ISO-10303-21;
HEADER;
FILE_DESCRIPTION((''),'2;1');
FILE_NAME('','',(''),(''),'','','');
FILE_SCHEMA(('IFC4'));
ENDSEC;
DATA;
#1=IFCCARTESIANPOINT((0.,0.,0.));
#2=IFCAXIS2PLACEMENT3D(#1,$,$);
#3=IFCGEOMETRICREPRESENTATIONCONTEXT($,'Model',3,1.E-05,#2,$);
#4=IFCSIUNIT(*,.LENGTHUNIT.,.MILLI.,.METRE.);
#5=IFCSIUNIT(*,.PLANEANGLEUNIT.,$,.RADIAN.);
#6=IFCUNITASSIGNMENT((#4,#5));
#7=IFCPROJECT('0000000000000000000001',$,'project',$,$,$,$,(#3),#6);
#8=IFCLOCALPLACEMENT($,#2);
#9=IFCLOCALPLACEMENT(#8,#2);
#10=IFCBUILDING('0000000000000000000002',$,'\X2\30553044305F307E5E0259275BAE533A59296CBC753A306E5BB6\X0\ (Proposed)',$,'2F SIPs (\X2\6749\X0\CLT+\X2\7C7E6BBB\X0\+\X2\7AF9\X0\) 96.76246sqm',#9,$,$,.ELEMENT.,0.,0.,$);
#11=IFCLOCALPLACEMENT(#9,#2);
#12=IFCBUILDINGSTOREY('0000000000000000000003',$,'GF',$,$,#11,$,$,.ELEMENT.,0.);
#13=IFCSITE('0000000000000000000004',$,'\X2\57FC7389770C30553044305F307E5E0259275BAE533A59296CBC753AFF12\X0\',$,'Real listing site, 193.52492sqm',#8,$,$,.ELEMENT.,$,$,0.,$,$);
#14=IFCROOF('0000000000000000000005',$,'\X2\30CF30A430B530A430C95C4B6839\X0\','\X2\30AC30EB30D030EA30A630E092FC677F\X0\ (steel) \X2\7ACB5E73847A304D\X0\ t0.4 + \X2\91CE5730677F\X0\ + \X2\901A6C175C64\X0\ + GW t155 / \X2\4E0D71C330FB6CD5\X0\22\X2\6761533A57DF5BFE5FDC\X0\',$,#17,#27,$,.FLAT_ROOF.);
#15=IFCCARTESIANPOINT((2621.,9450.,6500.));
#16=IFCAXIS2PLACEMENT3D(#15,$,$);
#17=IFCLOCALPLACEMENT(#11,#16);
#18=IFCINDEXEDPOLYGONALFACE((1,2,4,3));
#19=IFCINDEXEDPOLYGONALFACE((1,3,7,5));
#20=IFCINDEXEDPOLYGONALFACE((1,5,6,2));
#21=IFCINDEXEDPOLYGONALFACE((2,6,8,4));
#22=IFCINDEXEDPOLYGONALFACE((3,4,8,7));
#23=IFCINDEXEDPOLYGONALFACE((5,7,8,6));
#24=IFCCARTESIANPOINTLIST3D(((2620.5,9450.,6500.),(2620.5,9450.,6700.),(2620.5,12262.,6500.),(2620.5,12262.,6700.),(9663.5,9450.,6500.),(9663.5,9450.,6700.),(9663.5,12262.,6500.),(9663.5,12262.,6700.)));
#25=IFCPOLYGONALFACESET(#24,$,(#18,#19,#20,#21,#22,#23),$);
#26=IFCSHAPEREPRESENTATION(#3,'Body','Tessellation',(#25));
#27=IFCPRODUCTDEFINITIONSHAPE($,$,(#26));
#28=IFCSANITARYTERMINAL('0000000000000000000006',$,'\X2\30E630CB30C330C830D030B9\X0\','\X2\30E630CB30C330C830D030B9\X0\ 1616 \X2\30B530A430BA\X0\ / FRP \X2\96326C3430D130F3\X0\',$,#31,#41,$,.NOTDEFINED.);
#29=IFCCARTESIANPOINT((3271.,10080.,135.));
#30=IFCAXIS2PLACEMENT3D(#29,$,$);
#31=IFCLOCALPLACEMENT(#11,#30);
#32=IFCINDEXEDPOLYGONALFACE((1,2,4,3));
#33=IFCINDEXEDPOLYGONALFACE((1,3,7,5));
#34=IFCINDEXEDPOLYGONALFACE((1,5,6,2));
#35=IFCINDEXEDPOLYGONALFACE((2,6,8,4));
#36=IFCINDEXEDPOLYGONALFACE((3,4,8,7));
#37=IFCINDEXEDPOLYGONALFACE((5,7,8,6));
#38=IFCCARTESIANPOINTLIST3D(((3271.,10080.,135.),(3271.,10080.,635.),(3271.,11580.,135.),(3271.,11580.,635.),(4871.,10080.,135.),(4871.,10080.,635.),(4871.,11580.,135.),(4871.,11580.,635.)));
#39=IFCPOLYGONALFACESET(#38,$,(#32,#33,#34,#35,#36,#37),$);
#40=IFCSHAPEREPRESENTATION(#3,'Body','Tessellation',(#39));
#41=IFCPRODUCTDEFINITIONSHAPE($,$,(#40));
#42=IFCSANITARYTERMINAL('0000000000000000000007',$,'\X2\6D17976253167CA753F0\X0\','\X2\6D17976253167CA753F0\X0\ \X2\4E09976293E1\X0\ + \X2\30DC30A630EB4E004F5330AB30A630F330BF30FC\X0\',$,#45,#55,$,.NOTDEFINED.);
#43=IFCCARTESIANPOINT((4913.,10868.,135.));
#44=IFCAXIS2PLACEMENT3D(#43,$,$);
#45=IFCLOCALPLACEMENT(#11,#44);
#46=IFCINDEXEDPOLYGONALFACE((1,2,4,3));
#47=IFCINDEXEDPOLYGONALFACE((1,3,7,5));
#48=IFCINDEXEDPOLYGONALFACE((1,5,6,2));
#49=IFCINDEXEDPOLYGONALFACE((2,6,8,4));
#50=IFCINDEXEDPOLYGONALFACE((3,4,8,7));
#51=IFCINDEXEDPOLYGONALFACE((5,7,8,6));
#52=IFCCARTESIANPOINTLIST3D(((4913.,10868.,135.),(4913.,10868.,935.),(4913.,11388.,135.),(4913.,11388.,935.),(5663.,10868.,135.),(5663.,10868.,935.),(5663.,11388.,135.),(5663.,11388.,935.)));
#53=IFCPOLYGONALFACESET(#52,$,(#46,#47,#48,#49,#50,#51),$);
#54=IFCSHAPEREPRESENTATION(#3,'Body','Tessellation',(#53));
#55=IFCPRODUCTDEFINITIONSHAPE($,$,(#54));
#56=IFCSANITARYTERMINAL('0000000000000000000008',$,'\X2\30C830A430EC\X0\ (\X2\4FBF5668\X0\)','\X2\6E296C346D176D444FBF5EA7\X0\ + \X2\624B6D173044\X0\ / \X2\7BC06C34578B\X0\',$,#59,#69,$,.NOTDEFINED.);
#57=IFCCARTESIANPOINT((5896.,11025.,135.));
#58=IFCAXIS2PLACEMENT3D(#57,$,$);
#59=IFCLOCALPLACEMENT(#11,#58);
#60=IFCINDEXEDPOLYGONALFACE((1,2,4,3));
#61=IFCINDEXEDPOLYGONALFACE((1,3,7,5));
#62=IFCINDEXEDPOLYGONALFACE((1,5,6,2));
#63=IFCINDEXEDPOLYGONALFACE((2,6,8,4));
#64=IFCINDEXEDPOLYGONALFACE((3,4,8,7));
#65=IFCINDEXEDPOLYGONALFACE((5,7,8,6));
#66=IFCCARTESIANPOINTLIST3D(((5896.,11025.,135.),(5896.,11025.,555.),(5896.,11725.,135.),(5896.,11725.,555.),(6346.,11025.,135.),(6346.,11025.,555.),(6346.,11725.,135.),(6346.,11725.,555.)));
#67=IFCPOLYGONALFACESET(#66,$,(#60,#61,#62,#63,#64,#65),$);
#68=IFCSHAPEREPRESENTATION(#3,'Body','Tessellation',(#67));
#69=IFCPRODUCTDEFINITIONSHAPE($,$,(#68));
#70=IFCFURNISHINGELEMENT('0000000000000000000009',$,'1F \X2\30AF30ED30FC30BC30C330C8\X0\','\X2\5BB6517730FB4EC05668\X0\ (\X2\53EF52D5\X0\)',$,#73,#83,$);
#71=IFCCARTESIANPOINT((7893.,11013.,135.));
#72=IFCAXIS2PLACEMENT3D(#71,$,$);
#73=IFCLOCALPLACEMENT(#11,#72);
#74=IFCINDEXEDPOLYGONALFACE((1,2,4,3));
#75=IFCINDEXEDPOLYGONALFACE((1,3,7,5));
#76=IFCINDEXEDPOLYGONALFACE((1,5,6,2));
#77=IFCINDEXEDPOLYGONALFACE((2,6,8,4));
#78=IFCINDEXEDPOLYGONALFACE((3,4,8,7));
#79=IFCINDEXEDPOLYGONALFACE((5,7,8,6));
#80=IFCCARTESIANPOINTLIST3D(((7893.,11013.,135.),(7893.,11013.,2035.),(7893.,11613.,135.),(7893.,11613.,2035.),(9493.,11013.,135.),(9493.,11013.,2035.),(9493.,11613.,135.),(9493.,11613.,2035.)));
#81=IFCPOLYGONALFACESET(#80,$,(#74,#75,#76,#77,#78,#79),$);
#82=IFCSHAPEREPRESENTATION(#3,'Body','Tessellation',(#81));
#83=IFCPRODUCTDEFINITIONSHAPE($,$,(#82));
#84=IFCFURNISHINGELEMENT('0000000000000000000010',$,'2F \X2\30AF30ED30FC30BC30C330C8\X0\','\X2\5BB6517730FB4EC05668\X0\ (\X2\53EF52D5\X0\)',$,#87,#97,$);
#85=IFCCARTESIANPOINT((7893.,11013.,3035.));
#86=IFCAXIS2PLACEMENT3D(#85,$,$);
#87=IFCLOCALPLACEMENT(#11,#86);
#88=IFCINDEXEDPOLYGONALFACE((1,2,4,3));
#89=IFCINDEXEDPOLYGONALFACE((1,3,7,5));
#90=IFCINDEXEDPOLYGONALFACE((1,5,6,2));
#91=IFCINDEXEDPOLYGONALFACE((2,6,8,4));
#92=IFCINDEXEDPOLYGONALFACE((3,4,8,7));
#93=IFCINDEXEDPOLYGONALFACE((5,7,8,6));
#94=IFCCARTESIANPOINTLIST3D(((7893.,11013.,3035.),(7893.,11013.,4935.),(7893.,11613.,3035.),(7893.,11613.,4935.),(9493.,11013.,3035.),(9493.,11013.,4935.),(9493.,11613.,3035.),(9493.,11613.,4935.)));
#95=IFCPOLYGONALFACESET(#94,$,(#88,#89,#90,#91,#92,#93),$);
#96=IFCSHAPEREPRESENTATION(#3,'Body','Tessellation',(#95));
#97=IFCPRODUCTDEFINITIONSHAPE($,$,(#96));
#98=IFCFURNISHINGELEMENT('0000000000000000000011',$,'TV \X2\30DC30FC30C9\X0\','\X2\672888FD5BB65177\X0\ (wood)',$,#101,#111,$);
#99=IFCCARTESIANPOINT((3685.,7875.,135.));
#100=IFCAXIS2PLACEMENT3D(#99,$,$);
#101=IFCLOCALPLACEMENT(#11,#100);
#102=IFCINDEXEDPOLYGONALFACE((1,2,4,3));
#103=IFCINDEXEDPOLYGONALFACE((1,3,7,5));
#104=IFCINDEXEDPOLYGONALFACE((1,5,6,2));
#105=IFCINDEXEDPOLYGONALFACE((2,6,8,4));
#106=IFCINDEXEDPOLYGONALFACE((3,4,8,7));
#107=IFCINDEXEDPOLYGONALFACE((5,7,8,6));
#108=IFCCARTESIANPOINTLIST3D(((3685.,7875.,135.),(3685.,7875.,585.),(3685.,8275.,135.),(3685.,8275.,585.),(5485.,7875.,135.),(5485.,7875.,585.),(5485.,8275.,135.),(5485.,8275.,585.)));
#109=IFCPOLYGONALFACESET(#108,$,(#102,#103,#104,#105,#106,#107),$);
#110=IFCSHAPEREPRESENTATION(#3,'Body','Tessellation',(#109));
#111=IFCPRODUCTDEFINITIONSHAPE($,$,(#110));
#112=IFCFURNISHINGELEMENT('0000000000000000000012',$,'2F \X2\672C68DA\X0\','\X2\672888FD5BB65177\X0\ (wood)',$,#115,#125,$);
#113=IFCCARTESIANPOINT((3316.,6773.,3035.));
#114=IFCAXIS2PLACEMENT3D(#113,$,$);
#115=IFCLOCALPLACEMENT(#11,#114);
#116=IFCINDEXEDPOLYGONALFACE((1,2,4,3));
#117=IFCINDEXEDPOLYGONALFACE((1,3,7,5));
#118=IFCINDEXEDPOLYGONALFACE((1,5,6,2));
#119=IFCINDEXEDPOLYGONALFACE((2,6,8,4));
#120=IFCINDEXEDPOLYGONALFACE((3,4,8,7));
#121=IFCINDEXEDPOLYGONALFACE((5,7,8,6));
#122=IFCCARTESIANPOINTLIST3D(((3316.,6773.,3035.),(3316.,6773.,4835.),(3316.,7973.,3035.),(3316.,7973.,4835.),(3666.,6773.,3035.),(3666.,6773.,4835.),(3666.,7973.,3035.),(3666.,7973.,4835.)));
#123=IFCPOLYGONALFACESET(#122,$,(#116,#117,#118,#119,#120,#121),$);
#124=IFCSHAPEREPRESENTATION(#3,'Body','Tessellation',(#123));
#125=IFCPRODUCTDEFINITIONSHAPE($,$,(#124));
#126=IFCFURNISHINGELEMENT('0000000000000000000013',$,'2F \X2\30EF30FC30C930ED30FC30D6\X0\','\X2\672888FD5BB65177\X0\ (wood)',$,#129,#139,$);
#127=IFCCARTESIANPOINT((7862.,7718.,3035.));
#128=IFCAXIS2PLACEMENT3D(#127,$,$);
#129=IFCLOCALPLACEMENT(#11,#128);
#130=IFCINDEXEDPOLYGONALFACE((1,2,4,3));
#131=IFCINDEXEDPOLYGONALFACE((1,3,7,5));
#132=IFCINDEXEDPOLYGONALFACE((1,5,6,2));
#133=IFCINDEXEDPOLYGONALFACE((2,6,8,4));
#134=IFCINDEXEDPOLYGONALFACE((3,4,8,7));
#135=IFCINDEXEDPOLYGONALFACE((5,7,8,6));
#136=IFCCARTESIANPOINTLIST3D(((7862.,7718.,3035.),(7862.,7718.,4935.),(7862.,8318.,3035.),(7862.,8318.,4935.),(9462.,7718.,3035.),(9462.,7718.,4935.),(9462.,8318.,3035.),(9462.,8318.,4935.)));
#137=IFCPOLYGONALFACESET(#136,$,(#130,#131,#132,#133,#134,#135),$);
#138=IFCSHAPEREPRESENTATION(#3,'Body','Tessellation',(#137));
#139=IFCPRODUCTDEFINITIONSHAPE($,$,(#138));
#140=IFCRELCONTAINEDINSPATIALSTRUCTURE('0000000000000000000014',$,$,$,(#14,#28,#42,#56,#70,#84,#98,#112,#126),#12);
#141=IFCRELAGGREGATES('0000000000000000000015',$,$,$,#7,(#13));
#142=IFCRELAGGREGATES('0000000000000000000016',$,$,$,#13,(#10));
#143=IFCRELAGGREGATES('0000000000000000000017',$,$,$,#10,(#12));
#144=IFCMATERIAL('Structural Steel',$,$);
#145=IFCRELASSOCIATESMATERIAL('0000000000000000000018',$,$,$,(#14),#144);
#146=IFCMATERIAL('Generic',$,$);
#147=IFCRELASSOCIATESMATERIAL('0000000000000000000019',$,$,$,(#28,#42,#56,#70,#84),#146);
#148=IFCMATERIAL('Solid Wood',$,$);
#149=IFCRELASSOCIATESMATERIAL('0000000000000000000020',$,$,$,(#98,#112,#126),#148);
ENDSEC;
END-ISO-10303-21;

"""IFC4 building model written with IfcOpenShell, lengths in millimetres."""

from ifc_helpers import new_model, si_unit, frame, frame_2d, origin, place, context, project, spatial, rectangle, extrude, material, element, save


model = new_model("IFC4")

# Units and contexts
model_context = context("Model", 3, precision=1e-05, world=origin())
ifc_project = project(units=[si_unit("LENGTHUNIT", "METRE", prefix="MILLI"), si_unit("PLANEANGLEUNIT", "RADIAN")], contexts=[model_context])

# Site, building, storey
site_placement = place(None, origin())
site = spatial("IfcSite", under=ifc_project, at=site_placement, Name="埼玉県さいたま市大宮区天沼町２", ObjectType="Real listing site, 193.52492sqm", CompositionType="ELEMENT", RefElevation=0.0)
building_placement = place(site_placement, origin())
building = spatial("IfcBuilding", under=site, at=building_placement, Name="さいたま市大宮区天沼町の家 (Proposed)", ObjectType="2F SIPs (杉CLT+籾殻+竹) 96.76246sqm", CompositionType="ELEMENT", ElevationOfRefHeight=0.0, ElevationOfTerrain=0.0)
storey_placement = place(building_placement, origin())
storey = spatial("IfcBuildingStorey", under=building, at=storey_placement, Name="GF", CompositionType="ELEMENT", Elevation=0.0)

# Shared definitions
ifc_material_1 = material(Name="Solid Wood")

# Roof
ifc_material_2 = material(Name="Structural Steel")
roof_placement = place(storey_placement, frame((2621.0, 9450.0, 6500.0)))
element("IfcRoof", 1, at=roof_placement, inside=storey, material=ifc_material_2, Name="ハイサイド屋根", Description="ガルバリウム鋼板 (steel) 立平葺き t0.4 + 野地板 + 通気層 + GW t155 / 不燃・法22条区域対応", PredefinedType="FLAT_ROOF", context=model_context, shape_type="SweptSolid", body=[
    extrude(rectangle(XDim=7043.0, YDim=2812.0, at=frame_2d((3521.0, 1406.0))), frame((2621.0, 9450.0, 6500.0)), (0.0, 0.0, 1.0), 200.0),
])

# Sanitary terminals
ifc_material_3 = material(Name="Generic")
sanitary_terminal_1_placement = place(storey_placement, frame((3271.0, 10080.0, 135.0)))
element("IfcSanitaryTerminal", 2, at=sanitary_terminal_1_placement, inside=storey, material=ifc_material_3, Name="ユニットバス", Description="ユニットバス 1616 サイズ / FRP 防水パン", PredefinedType="NOTDEFINED", context=model_context, shape_type="SweptSolid", body=[
    extrude(rectangle(XDim=1600.0, YDim=1500.0, at=frame_2d((800.0, 750.0))), frame((3271.0, 10080.0, 135.0)), (0.0, 0.0, 1.0), 500.0),
])
sanitary_terminal_2_placement = place(storey_placement, frame((4913.0, 10868.0, 135.0)))
element("IfcSanitaryTerminal", 3, at=sanitary_terminal_2_placement, inside=storey, material=ifc_material_3, Name="洗面化粧台", Description="洗面化粧台 三面鏡 + ボウル一体カウンター", PredefinedType="NOTDEFINED", context=model_context, shape_type="SweptSolid", body=[
    extrude(rectangle(XDim=750.0, YDim=520.0, at=frame_2d((375.0, 260.0))), frame((4913.0, 10868.0, 135.0)), (0.0, 0.0, 1.0), 800.0),
])
sanitary_terminal_3_placement = place(storey_placement, frame((5896.0, 11025.0, 135.0)))
element("IfcSanitaryTerminal", 4, at=sanitary_terminal_3_placement, inside=storey, material=ifc_material_3, Name="トイレ (便器)", Description="温水洗浄便座 + 手洗い / 節水型", PredefinedType="NOTDEFINED", context=model_context, shape_type="SweptSolid", body=[
    extrude(rectangle(XDim=450.0, YDim=700.0, at=frame_2d((225.0, 350.0))), frame((5896.0, 11025.0, 135.0)), (0.0, 0.0, 1.0), 420.0),
])

# Furnishing elements
furnishing_1_placement = place(storey_placement, frame((7893.0, 11013.0, 135.0)))
element("IfcFurnishingElement", 5, at=furnishing_1_placement, inside=storey, material=ifc_material_3, Name="1F クローゼット", Description="家具・什器 (可動)", context=model_context, shape_type="SweptSolid", body=[
    extrude(rectangle(XDim=1600.0, YDim=600.0, at=frame_2d((800.0, 300.0))), frame((7893.0, 11013.0, 135.0)), (0.0, 0.0, 1.0), 1900.0),
])
furnishing_2_placement = place(storey_placement, frame((7893.0, 11013.0, 3035.0)))
element("IfcFurnishingElement", 6, at=furnishing_2_placement, inside=storey, material=ifc_material_3, Name="2F クローゼット", Description="家具・什器 (可動)", context=model_context, shape_type="SweptSolid", body=[
    extrude(rectangle(XDim=1600.0, YDim=600.0, at=frame_2d((800.0, 300.0))), frame((7893.0, 11013.0, 3035.0)), (0.0, 0.0, 1.0), 1900.0),
])
furnishing_3_placement = place(storey_placement, frame((3685.0, 7875.0, 135.0)))
element("IfcFurnishingElement", 7, at=furnishing_3_placement, inside=storey, material=ifc_material_1, Name="TV ボード", Description="木製家具 (wood)", context=model_context, shape_type="SweptSolid", body=[
    extrude(rectangle(XDim=1800.0, YDim=400.0, at=frame_2d((900.0, 200.0))), frame((3685.0, 7875.0, 135.0)), (0.0, 0.0, 1.0), 450.0),
])
furnishing_4_placement = place(storey_placement, frame((3316.0, 6773.0, 3035.0)))
element("IfcFurnishingElement", 8, at=furnishing_4_placement, inside=storey, material=ifc_material_1, Name="2F 本棚", Description="木製家具 (wood)", context=model_context, shape_type="SweptSolid", body=[
    extrude(rectangle(XDim=350.0, YDim=1200.0, at=frame_2d((175.0, 600.0))), frame((3316.0, 6773.0, 3035.0)), (0.0, 0.0, 1.0), 1800.0),
])
furnishing_5_placement = place(storey_placement, frame((7862.0, 7718.0, 3035.0)))
element("IfcFurnishingElement", 9, at=furnishing_5_placement, inside=storey, material=ifc_material_1, Name="2F ワードローブ", Description="木製家具 (wood)", context=model_context, shape_type="SweptSolid", body=[
    extrude(rectangle(XDim=1600.0, YDim=600.0, at=frame_2d((800.0, 300.0))), frame((7862.0, 7718.0, 3035.0)), (0.0, 0.0, 1.0), 1900.0),
])

save(model, "model.ifc")
